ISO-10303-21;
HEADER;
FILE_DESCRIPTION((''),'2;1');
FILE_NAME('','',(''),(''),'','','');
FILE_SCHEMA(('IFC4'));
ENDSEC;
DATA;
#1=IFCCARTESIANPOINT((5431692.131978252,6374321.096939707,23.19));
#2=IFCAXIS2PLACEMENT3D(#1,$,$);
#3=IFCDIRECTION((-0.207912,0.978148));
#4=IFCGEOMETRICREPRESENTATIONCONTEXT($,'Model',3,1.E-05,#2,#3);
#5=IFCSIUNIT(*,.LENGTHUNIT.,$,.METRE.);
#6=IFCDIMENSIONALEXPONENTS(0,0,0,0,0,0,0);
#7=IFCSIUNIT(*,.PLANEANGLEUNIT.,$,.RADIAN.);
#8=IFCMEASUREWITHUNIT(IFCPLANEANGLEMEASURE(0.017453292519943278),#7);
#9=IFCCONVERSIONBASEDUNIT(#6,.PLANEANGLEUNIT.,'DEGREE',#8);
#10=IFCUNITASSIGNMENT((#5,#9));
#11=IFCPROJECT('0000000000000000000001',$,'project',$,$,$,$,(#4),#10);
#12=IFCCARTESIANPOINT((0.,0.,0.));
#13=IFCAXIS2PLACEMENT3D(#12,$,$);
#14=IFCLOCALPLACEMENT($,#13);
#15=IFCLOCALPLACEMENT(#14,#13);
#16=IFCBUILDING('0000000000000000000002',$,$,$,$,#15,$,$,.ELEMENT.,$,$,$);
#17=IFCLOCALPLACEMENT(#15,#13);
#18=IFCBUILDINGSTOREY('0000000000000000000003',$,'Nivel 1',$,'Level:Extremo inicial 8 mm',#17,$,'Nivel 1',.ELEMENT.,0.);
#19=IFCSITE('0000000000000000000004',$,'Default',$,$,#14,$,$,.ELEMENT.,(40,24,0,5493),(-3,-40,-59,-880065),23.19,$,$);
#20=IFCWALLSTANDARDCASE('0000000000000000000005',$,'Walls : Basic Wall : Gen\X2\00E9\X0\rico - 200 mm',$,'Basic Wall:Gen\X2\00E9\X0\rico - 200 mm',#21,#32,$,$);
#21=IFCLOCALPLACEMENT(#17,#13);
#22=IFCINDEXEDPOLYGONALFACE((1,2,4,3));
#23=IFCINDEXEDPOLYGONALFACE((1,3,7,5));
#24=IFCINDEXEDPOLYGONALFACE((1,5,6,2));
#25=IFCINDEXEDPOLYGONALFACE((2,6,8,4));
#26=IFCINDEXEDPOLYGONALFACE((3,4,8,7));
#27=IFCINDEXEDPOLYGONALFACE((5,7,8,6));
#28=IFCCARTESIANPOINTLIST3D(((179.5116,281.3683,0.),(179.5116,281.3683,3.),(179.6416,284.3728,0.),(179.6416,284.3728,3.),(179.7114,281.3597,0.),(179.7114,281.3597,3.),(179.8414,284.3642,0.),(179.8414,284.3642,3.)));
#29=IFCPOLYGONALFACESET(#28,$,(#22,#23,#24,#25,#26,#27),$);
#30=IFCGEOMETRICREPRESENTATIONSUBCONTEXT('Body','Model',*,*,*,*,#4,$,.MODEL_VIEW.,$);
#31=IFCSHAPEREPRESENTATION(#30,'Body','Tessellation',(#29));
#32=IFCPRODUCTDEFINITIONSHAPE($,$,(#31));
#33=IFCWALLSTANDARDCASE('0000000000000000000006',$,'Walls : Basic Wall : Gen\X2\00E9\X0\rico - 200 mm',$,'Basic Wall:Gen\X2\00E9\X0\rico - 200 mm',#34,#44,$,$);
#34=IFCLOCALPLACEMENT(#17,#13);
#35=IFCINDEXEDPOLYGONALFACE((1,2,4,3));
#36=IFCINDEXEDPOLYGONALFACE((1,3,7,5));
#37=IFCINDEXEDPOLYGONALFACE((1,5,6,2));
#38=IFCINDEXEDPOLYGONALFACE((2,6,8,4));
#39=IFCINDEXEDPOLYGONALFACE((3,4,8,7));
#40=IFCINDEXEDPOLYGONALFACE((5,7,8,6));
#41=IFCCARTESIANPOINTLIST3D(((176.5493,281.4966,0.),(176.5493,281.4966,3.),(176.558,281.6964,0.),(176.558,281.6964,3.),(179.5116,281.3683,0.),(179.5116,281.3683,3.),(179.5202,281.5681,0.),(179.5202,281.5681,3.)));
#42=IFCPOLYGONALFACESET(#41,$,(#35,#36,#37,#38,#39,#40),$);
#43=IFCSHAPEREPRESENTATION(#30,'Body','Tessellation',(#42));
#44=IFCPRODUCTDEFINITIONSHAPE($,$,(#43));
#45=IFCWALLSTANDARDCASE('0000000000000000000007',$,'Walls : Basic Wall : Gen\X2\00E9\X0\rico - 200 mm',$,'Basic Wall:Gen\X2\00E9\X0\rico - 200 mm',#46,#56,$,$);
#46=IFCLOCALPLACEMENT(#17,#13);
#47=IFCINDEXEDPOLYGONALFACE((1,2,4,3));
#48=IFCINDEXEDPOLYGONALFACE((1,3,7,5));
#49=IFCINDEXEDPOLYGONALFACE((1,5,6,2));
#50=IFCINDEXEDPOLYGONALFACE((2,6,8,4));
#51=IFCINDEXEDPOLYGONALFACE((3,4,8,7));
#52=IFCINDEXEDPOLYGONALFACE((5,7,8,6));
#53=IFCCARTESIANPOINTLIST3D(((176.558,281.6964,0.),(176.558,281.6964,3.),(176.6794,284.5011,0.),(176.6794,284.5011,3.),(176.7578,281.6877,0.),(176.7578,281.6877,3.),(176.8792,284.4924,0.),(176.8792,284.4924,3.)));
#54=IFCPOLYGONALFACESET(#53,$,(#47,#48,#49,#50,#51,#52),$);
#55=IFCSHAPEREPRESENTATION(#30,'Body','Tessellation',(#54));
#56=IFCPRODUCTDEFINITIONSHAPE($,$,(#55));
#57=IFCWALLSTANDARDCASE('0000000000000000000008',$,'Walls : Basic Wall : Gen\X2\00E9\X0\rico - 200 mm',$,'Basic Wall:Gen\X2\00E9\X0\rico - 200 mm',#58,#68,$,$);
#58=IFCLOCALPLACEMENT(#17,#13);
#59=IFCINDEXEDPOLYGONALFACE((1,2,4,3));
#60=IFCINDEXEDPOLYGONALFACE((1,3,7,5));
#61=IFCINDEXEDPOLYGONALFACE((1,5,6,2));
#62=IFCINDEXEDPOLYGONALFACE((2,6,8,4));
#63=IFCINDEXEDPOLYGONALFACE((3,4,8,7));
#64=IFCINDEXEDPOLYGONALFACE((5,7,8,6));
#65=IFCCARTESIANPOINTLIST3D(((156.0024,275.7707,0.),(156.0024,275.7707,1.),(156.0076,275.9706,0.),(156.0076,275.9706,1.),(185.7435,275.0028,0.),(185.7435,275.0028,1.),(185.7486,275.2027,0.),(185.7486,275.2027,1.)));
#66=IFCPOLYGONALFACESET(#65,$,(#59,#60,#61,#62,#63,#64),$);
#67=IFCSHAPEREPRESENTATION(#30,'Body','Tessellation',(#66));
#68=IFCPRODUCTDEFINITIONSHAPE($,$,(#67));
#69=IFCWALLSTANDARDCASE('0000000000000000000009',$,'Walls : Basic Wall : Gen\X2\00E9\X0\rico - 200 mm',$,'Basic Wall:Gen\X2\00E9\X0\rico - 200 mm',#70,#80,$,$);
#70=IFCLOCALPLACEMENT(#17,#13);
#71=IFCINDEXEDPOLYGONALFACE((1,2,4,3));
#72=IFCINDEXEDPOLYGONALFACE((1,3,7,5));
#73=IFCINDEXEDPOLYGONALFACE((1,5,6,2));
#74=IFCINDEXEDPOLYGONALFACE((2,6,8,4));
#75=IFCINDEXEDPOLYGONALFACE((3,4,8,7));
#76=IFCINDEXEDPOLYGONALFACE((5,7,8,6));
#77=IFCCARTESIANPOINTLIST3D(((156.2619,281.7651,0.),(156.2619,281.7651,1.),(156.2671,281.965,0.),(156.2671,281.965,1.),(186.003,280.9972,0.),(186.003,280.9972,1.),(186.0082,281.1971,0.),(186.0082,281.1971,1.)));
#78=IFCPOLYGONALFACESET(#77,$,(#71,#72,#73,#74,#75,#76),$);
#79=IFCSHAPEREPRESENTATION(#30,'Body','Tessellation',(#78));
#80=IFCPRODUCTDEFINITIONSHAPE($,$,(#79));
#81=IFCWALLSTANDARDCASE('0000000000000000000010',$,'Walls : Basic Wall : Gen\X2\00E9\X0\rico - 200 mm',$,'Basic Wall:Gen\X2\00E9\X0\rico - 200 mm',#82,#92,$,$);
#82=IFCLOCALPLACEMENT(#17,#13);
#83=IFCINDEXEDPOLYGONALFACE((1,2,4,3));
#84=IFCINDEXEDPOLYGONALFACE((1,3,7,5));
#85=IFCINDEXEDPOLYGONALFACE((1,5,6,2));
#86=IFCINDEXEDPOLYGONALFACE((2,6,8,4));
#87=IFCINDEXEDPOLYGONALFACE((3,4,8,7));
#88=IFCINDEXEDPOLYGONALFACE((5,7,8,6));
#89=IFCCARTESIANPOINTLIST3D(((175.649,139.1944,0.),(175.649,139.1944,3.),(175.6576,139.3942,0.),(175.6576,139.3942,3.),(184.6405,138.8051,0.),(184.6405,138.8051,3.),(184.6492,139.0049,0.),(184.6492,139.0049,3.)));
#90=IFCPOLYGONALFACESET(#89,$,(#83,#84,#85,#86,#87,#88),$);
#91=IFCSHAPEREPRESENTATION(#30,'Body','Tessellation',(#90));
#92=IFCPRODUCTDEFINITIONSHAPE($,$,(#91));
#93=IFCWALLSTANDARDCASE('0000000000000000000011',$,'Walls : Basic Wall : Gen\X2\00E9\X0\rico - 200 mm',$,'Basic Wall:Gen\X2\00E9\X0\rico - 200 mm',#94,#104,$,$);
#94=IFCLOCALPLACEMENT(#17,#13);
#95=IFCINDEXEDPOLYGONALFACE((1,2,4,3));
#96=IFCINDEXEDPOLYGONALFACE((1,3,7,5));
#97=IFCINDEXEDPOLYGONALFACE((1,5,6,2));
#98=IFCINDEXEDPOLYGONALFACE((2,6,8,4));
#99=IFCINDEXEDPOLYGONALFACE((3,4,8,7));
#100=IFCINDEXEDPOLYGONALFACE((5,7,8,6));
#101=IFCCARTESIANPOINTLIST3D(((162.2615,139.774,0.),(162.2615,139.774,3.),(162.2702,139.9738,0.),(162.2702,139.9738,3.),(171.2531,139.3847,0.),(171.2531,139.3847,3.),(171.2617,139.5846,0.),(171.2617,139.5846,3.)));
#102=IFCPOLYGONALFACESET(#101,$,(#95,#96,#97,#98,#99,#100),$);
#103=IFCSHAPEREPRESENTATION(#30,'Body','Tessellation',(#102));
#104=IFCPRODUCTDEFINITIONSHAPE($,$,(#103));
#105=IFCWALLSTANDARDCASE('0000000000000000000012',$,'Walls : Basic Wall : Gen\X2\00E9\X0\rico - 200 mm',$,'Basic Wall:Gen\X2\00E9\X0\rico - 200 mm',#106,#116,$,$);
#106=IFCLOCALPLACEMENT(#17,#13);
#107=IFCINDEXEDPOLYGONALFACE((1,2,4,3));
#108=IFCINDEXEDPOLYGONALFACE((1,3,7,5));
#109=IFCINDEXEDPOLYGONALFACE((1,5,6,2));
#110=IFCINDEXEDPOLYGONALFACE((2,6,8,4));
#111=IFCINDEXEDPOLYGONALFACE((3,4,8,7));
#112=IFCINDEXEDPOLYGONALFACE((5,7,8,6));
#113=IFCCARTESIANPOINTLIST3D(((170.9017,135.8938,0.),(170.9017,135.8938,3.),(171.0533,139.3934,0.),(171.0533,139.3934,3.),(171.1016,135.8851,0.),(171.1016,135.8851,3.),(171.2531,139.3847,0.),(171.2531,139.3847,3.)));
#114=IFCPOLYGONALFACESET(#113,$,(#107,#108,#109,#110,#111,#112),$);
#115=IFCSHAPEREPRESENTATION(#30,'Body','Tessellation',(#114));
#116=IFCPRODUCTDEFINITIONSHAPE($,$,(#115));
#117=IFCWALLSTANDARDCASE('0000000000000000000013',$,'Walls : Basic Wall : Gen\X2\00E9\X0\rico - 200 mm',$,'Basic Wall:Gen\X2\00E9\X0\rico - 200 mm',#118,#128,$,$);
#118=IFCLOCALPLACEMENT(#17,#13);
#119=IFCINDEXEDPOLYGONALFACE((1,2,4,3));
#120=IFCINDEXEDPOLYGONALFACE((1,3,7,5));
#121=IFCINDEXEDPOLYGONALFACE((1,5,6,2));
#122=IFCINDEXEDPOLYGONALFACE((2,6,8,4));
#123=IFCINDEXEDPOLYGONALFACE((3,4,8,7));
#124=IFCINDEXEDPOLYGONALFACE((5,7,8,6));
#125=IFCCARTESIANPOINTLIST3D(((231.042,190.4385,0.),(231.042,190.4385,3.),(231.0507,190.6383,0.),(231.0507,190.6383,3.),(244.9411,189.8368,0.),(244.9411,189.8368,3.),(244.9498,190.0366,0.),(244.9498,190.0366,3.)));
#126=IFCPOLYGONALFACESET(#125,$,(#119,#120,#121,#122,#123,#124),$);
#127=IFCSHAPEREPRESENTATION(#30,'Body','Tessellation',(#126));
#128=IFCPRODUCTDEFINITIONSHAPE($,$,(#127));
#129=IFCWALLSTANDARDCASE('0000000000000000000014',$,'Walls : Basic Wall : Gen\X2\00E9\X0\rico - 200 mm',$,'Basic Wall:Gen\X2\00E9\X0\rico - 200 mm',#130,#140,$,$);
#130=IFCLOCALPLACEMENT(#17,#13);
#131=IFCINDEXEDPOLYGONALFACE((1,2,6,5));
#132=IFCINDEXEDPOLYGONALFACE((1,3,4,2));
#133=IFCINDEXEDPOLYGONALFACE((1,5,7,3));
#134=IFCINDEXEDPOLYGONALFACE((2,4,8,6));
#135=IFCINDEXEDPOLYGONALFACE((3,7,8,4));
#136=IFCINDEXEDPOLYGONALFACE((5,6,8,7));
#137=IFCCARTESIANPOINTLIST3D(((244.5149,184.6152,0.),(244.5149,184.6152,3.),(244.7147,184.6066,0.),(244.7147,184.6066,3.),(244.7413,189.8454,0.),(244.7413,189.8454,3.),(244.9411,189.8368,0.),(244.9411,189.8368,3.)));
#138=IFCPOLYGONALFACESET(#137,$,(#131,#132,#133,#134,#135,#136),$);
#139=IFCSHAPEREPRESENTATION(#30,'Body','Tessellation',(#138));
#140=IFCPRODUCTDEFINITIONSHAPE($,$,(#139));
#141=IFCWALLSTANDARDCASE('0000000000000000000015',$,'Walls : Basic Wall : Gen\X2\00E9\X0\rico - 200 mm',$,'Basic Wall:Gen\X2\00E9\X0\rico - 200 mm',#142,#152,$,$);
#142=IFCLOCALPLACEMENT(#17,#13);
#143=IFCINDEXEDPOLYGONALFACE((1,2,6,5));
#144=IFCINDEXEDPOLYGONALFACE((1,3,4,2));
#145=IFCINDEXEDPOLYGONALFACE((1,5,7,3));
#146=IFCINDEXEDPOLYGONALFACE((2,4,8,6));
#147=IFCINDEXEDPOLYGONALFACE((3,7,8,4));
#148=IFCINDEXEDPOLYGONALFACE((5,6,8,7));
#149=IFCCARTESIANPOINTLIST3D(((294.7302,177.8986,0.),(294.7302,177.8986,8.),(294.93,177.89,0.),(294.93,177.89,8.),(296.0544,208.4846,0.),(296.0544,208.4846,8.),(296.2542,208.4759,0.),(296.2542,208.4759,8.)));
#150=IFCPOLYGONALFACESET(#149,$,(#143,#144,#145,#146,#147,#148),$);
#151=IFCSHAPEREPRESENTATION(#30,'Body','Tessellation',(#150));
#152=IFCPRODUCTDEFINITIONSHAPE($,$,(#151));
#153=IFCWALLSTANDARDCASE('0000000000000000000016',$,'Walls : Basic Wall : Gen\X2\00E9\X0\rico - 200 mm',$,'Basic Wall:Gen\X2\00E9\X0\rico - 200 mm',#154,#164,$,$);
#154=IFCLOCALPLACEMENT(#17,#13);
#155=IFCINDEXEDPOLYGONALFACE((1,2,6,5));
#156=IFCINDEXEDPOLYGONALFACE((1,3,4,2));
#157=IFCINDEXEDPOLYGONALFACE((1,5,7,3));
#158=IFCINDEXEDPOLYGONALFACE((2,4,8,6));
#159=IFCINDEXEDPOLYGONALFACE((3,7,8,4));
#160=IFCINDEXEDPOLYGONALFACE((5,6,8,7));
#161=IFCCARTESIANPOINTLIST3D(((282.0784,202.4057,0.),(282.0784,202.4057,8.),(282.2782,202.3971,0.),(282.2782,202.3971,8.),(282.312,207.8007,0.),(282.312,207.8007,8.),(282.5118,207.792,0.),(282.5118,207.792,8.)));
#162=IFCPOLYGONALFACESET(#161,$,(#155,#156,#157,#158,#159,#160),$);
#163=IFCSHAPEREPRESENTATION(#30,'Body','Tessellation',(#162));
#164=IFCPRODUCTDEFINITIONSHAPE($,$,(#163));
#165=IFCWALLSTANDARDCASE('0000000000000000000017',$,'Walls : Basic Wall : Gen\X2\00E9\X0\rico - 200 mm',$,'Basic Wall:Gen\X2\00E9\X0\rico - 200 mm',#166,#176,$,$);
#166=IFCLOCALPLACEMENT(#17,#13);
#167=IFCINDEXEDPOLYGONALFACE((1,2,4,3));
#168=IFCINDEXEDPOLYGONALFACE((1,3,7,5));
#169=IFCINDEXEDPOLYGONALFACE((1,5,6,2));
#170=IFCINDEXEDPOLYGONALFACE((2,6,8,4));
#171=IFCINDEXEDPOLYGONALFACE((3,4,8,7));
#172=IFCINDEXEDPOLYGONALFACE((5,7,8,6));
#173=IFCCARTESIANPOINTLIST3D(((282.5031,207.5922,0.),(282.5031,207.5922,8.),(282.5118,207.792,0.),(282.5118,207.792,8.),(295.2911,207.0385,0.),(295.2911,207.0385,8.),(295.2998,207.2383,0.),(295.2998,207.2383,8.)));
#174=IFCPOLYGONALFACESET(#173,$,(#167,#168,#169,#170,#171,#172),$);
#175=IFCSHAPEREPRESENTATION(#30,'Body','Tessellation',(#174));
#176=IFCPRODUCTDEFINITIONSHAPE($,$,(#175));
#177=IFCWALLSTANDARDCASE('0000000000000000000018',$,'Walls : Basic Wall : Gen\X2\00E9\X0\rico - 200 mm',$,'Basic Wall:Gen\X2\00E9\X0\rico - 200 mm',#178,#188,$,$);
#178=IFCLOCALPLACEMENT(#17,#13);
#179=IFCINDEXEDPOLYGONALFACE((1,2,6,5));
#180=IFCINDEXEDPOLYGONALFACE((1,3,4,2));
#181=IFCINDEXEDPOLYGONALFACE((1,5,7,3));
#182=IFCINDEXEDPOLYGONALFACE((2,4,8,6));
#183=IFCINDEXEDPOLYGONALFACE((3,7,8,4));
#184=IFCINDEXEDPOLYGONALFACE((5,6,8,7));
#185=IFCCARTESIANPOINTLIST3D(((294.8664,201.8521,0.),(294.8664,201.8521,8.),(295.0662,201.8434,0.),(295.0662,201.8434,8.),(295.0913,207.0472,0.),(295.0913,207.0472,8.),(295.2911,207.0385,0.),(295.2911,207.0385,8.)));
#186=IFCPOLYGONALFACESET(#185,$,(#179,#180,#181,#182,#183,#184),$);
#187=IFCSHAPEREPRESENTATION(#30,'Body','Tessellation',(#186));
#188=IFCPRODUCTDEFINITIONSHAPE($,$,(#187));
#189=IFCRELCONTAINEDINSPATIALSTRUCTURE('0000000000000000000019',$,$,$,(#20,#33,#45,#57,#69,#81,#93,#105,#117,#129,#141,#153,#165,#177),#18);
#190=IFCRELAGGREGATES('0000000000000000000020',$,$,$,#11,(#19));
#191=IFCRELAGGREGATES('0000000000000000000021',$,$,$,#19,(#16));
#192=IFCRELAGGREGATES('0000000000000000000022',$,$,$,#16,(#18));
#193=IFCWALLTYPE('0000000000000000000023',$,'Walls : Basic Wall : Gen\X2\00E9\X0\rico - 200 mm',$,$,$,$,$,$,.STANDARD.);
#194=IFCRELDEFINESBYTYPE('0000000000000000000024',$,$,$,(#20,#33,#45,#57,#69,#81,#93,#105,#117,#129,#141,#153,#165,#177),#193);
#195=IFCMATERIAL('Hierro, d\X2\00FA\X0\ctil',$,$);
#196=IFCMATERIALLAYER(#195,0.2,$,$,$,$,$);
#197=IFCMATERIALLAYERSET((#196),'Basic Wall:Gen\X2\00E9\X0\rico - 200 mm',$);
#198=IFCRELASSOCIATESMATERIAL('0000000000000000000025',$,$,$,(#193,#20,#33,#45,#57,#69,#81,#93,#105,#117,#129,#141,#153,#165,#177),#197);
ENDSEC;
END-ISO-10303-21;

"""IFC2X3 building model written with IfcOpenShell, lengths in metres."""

from ifc_helpers import new_model, entity, si_unit, converted_unit, direction, frame, frame_2d, origin, place, context, subcontext, project, spatial, rectangle, extrude, material, layer, layer_set, layer_usage, type_object, element, save


model = new_model("IFC2X3")

# Units and contexts
model_context = context("Model", 3, precision=1e-05, world=frame((5431692.131978252, 6374321.096939707, 23.19)), true_north=direction((-0.207912, 0.978148)))
body_context = subcontext(model_context, "Body", "Model", "MODEL_VIEW")
ifc_project = project(units=[si_unit("LENGTHUNIT", "METRE"), converted_unit("PLANEANGLEUNIT", "DEGREE", entity("IfcPlaneAngleMeasure", 0.017453292519943278), si_unit("PLANEANGLEUNIT", "RADIAN"), dimensions=[0, 0, 0, 0, 0, 0, 0])], contexts=[model_context])

# Site, building, storey
site_placement = place(None, origin())
site = spatial("IfcSite", under=ifc_project, at=site_placement, Name="Default", CompositionType="ELEMENT", RefLatitude=(40, 24, 0, 5493), RefLongitude=(-3, -40, -59, -880065), RefElevation=23.19)
building_placement = place(site_placement, origin())
building = spatial("IfcBuilding", under=site, at=building_placement, CompositionType="ELEMENT")
storey_placement = place(building_placement, origin())
storey = spatial("IfcBuildingStorey", under=building, at=storey_placement, Name="Nivel 1", ObjectType="Level:Extremo inicial 8 mm", LongName="Nivel 1", CompositionType="ELEMENT", Elevation=0.0)

# Walls
ifc_material_1 = material(Name="Hierro, dúctil")
ifc_layer_1 = layer(ifc_material_1, 0.2)
ifc_layer_set_1 = layer_set([ifc_layer_1], Name="Basic Wall:Genérico - 200 mm")
wall_type = type_object("IfcWallType", Name="Walls : Basic Wall : Genérico - 200 mm", PredefinedType="STANDARD", material=ifc_layer_set_1)
ifc_layer_usage_1 = layer_usage(ifc_layer_set_1, "AXIS2", "NEGATIVE", 0.1)
wall_1_placement = place(storey_placement, frame((179.7415, 284.3685, 0.0), z_axis=(0.0, 0.0, 1.0), x_axis=(-0.043255, -0.999064, 0.0)))
element("IfcWallStandardCase", 1, at=wall_1_placement, inside=storey, type_object=wall_type, material=ifc_layer_usage_1, Name="Walls : Basic Wall : Genérico - 200 mm", ObjectType="Basic Wall:Genérico - 200 mm", context=body_context, shape_type="SweptSolid", body=[
    extrude(rectangle(XDim=3.0073, YDim=0.2, at=frame_2d((1.5037, 0.0), x_axis=(-1.0, 0.0))), origin(), (0.0, 0.0, 1.0), 3.0),
])
ifc_layer_usage_2 = layer_usage(ifc_layer_set_1, "AXIS2", "NEGATIVE", 0.1)
wall_2_placement = place(storey_placement, frame((179.5159, 281.4682, 0.0), z_axis=(0.0, 0.0, 1.0), x_axis=(-0.999064, 0.043255, 0.0)))
element("IfcWallStandardCase", 2, at=wall_2_placement, inside=storey, type_object=wall_type, material=ifc_layer_usage_2, Name="Walls : Basic Wall : Genérico - 200 mm", ObjectType="Basic Wall:Genérico - 200 mm", context=body_context, shape_type="SweptSolid", body=[
    extrude(rectangle(XDim=2.965, YDim=0.2, at=frame_2d((1.4825, 0.0), x_axis=(-1.0, 0.0))), origin(), (0.0, 0.0, 1.0), 3.0),
])
ifc_layer_usage_3 = layer_usage(ifc_layer_set_1, "AXIS2", "NEGATIVE", 0.1)
wall_3_placement = place(storey_placement, frame((176.6579, 281.6921, 0.0), z_axis=(0.0, 0.0, 1.0), x_axis=(0.043255, 0.999064, 0.0)))
element("IfcWallStandardCase", 3, at=wall_3_placement, inside=storey, type_object=wall_type, material=ifc_layer_usage_3, Name="Walls : Basic Wall : Genérico - 200 mm", ObjectType="Basic Wall:Genérico - 200 mm", context=body_context, shape_type="SweptSolid", body=[
    extrude(rectangle(XDim=2.8073, YDim=0.2, at=frame_2d((1.4037, 0.0), x_axis=(-1.0, 0.0))), origin(), (0.0, 0.0, 1.0), 3.0),
])
ifc_layer_usage_4 = layer_usage(ifc_layer_set_1, "AXIS2", "NEGATIVE", 0.1)
wall_4_placement = place(storey_placement, frame((185.7461, 275.1027, 0.0), z_axis=(0.0, 0.0, 1.0), x_axis=(-0.999667, 0.025812, 0.0)))
element("IfcWallStandardCase", 4, at=wall_4_placement, inside=storey, type_object=wall_type, material=ifc_layer_usage_4, Name="Walls : Basic Wall : Genérico - 200 mm", ObjectType="Basic Wall:Genérico - 200 mm", context=body_context, shape_type="SweptSolid", body=[
    extrude(rectangle(XDim=29.751, YDim=0.2, at=frame_2d((14.8755, 0.0), x_axis=(-1.0, 0.0))), origin(), (0.0, 0.0, 1.0), 1.0),
])
ifc_layer_usage_5 = layer_usage(ifc_layer_set_1, "AXIS2", "NEGATIVE", 0.1)
wall_5_placement = place(storey_placement, frame((186.0056, 281.0971, 0.0), z_axis=(0.0, 0.0, 1.0), x_axis=(-0.999667, 0.025812, 0.0)))
element("IfcWallStandardCase", 5, at=wall_5_placement, inside=storey, type_object=wall_type, material=ifc_layer_usage_5, Name="Walls : Basic Wall : Genérico - 200 mm", ObjectType="Basic Wall:Genérico - 200 mm", context=body_context, shape_type="SweptSolid", body=[
    extrude(rectangle(XDim=29.751, YDim=0.2, at=frame_2d((14.8755, 0.0), x_axis=(-1.0, 0.0))), origin(), (0.0, 0.0, 1.0), 1.0),
])
ifc_layer_usage_6 = layer_usage(ifc_layer_set_1, "AXIS2", "NEGATIVE", 0.1)
wall_6_placement = place(storey_placement, frame((175.6533, 139.2943, 0.0), z_axis=(0.0, 0.0, 1.0), x_axis=(0.999064, -0.043255, 0.0)))
element("IfcWallStandardCase", 6, at=wall_6_placement, inside=storey, type_object=wall_type, material=ifc_layer_usage_6, Name="Walls : Basic Wall : Genérico - 200 mm", ObjectType="Basic Wall:Genérico - 200 mm", context=body_context, shape_type="SweptSolid", body=[
    extrude(rectangle(XDim=9.0, YDim=0.2, at=frame_2d((4.5, 0.0), x_axis=(-1.0, 0.0))), origin(), (0.0, 0.0, 1.0), 3.0),
])
ifc_layer_usage_7 = layer_usage(ifc_layer_set_1, "AXIS2", "NEGATIVE", 0.1)
wall_7_placement = place(storey_placement, frame((162.2658, 139.8739, 0.0), z_axis=(0.0, 0.0, 1.0), x_axis=(0.999064, -0.043255, 0.0)))
element("IfcWallStandardCase", 7, at=wall_7_placement, inside=storey, type_object=wall_type, material=ifc_layer_usage_7, Name="Walls : Basic Wall : Genérico - 200 mm", ObjectType="Basic Wall:Genérico - 200 mm", context=body_context, shape_type="SweptSolid", body=[
    extrude(rectangle(XDim=9.0, YDim=0.2, at=frame_2d((4.5, 0.0), x_axis=(-1.0, 0.0))), origin(), (0.0, 0.0, 1.0), 3.0),
])
ifc_layer_usage_8 = layer_usage(ifc_layer_set_1, "AXIS2", "NEGATIVE", 0.1)
wall_8_placement = place(storey_placement, frame((171.1532, 139.3891, 0.0), z_axis=(0.0, 0.0, 1.0), x_axis=(-0.043255, -0.999064, 0.0)))
element("IfcWallStandardCase", 8, at=wall_8_placement, inside=storey, type_object=wall_type, material=ifc_layer_usage_8, Name="Walls : Basic Wall : Genérico - 200 mm", ObjectType="Basic Wall:Genérico - 200 mm", context=body_context, shape_type="SweptSolid", body=[
    extrude(rectangle(XDim=3.5029, YDim=0.2, at=frame_2d((1.7514, 0.0), x_axis=(-1.0, 0.0))), origin(), (0.0, 0.0, 1.0), 3.0),
])
ifc_layer_usage_9 = layer_usage(ifc_layer_set_1, "AXIS2", "NEGATIVE", 0.1)
wall_9_placement = place(storey_placement, frame((231.0463, 190.5384, 0.0), z_axis=(0.0, 0.0, 1.0), x_axis=(0.999064, -0.043255, 0.0)))
element("IfcWallStandardCase", 9, at=wall_9_placement, inside=storey, type_object=wall_type, material=ifc_layer_usage_9, Name="Walls : Basic Wall : Genérico - 200 mm", ObjectType="Basic Wall:Genérico - 200 mm", context=body_context, shape_type="SweptSolid", body=[
    extrude(rectangle(XDim=13.9122, YDim=0.2, at=frame_2d((6.9561, 0.0), x_axis=(-1.0, 0.0))), origin(), (0.0, 0.0, 1.0), 3.0),
])
ifc_layer_usage_10 = layer_usage(ifc_layer_set_1, "AXIS2", "NEGATIVE", 0.1)
wall_10_placement = place(storey_placement, frame((244.8412, 189.8411, 0.0), z_axis=(0.0, 0.0, 1.0), x_axis=(-0.043255, -0.999064, 0.0)))
element("IfcWallStandardCase", 10, at=wall_10_placement, inside=storey, type_object=wall_type, material=ifc_layer_usage_10, Name="Walls : Basic Wall : Genérico - 200 mm", ObjectType="Basic Wall:Genérico - 200 mm", context=body_context, shape_type="SweptSolid", body=[
    extrude(rectangle(XDim=5.2351, YDim=0.2, at=frame_2d((2.6175, 0.0), x_axis=(-1.0, 0.0))), origin(), (0.0, 0.0, 1.0), 3.0),
])
ifc_layer_usage_11 = layer_usage(ifc_layer_set_1, "AXIS2", "NEGATIVE", 0.1)
wall_11_placement = place(storey_placement, frame((294.8301, 177.8943, 0.0), z_axis=(0.0, 0.0, 1.0), x_axis=(0.043255, 0.999064, 0.0)))
element("IfcWallStandardCase", 11, at=wall_11_placement, inside=storey, type_object=wall_type, material=ifc_layer_usage_11, Name="Walls : Basic Wall : Genérico - 200 mm", ObjectType="Basic Wall:Genérico - 200 mm", context=body_context, shape_type="SweptSolid", body=[
    extrude(rectangle(XDim=30.6146, YDim=0.2, at=frame_2d((15.3073, 0.0), x_axis=(-1.0, 0.0))), origin(), (0.0, 0.0, 1.0), 8.0),
])
ifc_layer_usage_12 = layer_usage(ifc_layer_set_1, "AXIS2", "NEGATIVE", 0.1)
wall_12_placement = place(storey_placement, frame((282.1783, 202.4014, 0.0), z_axis=(0.0, 0.0, 1.0), x_axis=(0.043255, 0.999064, 0.0)))
element("IfcWallStandardCase", 12, at=wall_12_placement, inside=storey, type_object=wall_type, material=ifc_layer_usage_12, Name="Walls : Basic Wall : Genérico - 200 mm", ObjectType="Basic Wall:Genérico - 200 mm", context=body_context, shape_type="SweptSolid", body=[
    extrude(rectangle(XDim=5.4, YDim=0.2, at=frame_2d((2.7, 0.0), x_axis=(-1.0, 0.0))), origin(), (0.0, 0.0, 1.0), 8.0),
])
ifc_layer_usage_13 = layer_usage(ifc_layer_set_1, "AXIS2", "NEGATIVE", 0.1)
wall_13_placement = place(storey_placement, frame((282.5074, 207.6921, 0.0), z_axis=(0.0, 0.0, 1.0), x_axis=(0.999064, -0.043255, 0.0)))
element("IfcWallStandardCase", 13, at=wall_13_placement, inside=storey, type_object=wall_type, material=ifc_layer_usage_13, Name="Walls : Basic Wall : Genérico - 200 mm", ObjectType="Basic Wall:Genérico - 200 mm", context=body_context, shape_type="SweptSolid", body=[
    extrude(rectangle(XDim=12.8, YDim=0.2, at=frame_2d((6.4, 0.0), x_axis=(-1.0, 0.0))), origin(), (0.0, 0.0, 1.0), 8.0),
])
ifc_layer_usage_14 = layer_usage(ifc_layer_set_1, "AXIS2", "NEGATIVE", 0.1)
wall_14_placement = place(storey_placement, frame((295.1912, 207.0429, 0.0), z_axis=(0.0, 0.0, 1.0), x_axis=(-0.043255, -0.999064, 0.0)))
element("IfcWallStandardCase", 14, at=wall_14_placement, inside=storey, type_object=wall_type, material=ifc_layer_usage_14, Name="Walls : Basic Wall : Genérico - 200 mm", ObjectType="Basic Wall:Genérico - 200 mm", context=body_context, shape_type="SweptSolid", body=[
    extrude(rectangle(XDim=5.2, YDim=0.2, at=frame_2d((2.6, 0.0), x_axis=(-1.0, 0.0))), origin(), (0.0, 0.0, 1.0), 8.0),
])

save(model, "model.ifc")
